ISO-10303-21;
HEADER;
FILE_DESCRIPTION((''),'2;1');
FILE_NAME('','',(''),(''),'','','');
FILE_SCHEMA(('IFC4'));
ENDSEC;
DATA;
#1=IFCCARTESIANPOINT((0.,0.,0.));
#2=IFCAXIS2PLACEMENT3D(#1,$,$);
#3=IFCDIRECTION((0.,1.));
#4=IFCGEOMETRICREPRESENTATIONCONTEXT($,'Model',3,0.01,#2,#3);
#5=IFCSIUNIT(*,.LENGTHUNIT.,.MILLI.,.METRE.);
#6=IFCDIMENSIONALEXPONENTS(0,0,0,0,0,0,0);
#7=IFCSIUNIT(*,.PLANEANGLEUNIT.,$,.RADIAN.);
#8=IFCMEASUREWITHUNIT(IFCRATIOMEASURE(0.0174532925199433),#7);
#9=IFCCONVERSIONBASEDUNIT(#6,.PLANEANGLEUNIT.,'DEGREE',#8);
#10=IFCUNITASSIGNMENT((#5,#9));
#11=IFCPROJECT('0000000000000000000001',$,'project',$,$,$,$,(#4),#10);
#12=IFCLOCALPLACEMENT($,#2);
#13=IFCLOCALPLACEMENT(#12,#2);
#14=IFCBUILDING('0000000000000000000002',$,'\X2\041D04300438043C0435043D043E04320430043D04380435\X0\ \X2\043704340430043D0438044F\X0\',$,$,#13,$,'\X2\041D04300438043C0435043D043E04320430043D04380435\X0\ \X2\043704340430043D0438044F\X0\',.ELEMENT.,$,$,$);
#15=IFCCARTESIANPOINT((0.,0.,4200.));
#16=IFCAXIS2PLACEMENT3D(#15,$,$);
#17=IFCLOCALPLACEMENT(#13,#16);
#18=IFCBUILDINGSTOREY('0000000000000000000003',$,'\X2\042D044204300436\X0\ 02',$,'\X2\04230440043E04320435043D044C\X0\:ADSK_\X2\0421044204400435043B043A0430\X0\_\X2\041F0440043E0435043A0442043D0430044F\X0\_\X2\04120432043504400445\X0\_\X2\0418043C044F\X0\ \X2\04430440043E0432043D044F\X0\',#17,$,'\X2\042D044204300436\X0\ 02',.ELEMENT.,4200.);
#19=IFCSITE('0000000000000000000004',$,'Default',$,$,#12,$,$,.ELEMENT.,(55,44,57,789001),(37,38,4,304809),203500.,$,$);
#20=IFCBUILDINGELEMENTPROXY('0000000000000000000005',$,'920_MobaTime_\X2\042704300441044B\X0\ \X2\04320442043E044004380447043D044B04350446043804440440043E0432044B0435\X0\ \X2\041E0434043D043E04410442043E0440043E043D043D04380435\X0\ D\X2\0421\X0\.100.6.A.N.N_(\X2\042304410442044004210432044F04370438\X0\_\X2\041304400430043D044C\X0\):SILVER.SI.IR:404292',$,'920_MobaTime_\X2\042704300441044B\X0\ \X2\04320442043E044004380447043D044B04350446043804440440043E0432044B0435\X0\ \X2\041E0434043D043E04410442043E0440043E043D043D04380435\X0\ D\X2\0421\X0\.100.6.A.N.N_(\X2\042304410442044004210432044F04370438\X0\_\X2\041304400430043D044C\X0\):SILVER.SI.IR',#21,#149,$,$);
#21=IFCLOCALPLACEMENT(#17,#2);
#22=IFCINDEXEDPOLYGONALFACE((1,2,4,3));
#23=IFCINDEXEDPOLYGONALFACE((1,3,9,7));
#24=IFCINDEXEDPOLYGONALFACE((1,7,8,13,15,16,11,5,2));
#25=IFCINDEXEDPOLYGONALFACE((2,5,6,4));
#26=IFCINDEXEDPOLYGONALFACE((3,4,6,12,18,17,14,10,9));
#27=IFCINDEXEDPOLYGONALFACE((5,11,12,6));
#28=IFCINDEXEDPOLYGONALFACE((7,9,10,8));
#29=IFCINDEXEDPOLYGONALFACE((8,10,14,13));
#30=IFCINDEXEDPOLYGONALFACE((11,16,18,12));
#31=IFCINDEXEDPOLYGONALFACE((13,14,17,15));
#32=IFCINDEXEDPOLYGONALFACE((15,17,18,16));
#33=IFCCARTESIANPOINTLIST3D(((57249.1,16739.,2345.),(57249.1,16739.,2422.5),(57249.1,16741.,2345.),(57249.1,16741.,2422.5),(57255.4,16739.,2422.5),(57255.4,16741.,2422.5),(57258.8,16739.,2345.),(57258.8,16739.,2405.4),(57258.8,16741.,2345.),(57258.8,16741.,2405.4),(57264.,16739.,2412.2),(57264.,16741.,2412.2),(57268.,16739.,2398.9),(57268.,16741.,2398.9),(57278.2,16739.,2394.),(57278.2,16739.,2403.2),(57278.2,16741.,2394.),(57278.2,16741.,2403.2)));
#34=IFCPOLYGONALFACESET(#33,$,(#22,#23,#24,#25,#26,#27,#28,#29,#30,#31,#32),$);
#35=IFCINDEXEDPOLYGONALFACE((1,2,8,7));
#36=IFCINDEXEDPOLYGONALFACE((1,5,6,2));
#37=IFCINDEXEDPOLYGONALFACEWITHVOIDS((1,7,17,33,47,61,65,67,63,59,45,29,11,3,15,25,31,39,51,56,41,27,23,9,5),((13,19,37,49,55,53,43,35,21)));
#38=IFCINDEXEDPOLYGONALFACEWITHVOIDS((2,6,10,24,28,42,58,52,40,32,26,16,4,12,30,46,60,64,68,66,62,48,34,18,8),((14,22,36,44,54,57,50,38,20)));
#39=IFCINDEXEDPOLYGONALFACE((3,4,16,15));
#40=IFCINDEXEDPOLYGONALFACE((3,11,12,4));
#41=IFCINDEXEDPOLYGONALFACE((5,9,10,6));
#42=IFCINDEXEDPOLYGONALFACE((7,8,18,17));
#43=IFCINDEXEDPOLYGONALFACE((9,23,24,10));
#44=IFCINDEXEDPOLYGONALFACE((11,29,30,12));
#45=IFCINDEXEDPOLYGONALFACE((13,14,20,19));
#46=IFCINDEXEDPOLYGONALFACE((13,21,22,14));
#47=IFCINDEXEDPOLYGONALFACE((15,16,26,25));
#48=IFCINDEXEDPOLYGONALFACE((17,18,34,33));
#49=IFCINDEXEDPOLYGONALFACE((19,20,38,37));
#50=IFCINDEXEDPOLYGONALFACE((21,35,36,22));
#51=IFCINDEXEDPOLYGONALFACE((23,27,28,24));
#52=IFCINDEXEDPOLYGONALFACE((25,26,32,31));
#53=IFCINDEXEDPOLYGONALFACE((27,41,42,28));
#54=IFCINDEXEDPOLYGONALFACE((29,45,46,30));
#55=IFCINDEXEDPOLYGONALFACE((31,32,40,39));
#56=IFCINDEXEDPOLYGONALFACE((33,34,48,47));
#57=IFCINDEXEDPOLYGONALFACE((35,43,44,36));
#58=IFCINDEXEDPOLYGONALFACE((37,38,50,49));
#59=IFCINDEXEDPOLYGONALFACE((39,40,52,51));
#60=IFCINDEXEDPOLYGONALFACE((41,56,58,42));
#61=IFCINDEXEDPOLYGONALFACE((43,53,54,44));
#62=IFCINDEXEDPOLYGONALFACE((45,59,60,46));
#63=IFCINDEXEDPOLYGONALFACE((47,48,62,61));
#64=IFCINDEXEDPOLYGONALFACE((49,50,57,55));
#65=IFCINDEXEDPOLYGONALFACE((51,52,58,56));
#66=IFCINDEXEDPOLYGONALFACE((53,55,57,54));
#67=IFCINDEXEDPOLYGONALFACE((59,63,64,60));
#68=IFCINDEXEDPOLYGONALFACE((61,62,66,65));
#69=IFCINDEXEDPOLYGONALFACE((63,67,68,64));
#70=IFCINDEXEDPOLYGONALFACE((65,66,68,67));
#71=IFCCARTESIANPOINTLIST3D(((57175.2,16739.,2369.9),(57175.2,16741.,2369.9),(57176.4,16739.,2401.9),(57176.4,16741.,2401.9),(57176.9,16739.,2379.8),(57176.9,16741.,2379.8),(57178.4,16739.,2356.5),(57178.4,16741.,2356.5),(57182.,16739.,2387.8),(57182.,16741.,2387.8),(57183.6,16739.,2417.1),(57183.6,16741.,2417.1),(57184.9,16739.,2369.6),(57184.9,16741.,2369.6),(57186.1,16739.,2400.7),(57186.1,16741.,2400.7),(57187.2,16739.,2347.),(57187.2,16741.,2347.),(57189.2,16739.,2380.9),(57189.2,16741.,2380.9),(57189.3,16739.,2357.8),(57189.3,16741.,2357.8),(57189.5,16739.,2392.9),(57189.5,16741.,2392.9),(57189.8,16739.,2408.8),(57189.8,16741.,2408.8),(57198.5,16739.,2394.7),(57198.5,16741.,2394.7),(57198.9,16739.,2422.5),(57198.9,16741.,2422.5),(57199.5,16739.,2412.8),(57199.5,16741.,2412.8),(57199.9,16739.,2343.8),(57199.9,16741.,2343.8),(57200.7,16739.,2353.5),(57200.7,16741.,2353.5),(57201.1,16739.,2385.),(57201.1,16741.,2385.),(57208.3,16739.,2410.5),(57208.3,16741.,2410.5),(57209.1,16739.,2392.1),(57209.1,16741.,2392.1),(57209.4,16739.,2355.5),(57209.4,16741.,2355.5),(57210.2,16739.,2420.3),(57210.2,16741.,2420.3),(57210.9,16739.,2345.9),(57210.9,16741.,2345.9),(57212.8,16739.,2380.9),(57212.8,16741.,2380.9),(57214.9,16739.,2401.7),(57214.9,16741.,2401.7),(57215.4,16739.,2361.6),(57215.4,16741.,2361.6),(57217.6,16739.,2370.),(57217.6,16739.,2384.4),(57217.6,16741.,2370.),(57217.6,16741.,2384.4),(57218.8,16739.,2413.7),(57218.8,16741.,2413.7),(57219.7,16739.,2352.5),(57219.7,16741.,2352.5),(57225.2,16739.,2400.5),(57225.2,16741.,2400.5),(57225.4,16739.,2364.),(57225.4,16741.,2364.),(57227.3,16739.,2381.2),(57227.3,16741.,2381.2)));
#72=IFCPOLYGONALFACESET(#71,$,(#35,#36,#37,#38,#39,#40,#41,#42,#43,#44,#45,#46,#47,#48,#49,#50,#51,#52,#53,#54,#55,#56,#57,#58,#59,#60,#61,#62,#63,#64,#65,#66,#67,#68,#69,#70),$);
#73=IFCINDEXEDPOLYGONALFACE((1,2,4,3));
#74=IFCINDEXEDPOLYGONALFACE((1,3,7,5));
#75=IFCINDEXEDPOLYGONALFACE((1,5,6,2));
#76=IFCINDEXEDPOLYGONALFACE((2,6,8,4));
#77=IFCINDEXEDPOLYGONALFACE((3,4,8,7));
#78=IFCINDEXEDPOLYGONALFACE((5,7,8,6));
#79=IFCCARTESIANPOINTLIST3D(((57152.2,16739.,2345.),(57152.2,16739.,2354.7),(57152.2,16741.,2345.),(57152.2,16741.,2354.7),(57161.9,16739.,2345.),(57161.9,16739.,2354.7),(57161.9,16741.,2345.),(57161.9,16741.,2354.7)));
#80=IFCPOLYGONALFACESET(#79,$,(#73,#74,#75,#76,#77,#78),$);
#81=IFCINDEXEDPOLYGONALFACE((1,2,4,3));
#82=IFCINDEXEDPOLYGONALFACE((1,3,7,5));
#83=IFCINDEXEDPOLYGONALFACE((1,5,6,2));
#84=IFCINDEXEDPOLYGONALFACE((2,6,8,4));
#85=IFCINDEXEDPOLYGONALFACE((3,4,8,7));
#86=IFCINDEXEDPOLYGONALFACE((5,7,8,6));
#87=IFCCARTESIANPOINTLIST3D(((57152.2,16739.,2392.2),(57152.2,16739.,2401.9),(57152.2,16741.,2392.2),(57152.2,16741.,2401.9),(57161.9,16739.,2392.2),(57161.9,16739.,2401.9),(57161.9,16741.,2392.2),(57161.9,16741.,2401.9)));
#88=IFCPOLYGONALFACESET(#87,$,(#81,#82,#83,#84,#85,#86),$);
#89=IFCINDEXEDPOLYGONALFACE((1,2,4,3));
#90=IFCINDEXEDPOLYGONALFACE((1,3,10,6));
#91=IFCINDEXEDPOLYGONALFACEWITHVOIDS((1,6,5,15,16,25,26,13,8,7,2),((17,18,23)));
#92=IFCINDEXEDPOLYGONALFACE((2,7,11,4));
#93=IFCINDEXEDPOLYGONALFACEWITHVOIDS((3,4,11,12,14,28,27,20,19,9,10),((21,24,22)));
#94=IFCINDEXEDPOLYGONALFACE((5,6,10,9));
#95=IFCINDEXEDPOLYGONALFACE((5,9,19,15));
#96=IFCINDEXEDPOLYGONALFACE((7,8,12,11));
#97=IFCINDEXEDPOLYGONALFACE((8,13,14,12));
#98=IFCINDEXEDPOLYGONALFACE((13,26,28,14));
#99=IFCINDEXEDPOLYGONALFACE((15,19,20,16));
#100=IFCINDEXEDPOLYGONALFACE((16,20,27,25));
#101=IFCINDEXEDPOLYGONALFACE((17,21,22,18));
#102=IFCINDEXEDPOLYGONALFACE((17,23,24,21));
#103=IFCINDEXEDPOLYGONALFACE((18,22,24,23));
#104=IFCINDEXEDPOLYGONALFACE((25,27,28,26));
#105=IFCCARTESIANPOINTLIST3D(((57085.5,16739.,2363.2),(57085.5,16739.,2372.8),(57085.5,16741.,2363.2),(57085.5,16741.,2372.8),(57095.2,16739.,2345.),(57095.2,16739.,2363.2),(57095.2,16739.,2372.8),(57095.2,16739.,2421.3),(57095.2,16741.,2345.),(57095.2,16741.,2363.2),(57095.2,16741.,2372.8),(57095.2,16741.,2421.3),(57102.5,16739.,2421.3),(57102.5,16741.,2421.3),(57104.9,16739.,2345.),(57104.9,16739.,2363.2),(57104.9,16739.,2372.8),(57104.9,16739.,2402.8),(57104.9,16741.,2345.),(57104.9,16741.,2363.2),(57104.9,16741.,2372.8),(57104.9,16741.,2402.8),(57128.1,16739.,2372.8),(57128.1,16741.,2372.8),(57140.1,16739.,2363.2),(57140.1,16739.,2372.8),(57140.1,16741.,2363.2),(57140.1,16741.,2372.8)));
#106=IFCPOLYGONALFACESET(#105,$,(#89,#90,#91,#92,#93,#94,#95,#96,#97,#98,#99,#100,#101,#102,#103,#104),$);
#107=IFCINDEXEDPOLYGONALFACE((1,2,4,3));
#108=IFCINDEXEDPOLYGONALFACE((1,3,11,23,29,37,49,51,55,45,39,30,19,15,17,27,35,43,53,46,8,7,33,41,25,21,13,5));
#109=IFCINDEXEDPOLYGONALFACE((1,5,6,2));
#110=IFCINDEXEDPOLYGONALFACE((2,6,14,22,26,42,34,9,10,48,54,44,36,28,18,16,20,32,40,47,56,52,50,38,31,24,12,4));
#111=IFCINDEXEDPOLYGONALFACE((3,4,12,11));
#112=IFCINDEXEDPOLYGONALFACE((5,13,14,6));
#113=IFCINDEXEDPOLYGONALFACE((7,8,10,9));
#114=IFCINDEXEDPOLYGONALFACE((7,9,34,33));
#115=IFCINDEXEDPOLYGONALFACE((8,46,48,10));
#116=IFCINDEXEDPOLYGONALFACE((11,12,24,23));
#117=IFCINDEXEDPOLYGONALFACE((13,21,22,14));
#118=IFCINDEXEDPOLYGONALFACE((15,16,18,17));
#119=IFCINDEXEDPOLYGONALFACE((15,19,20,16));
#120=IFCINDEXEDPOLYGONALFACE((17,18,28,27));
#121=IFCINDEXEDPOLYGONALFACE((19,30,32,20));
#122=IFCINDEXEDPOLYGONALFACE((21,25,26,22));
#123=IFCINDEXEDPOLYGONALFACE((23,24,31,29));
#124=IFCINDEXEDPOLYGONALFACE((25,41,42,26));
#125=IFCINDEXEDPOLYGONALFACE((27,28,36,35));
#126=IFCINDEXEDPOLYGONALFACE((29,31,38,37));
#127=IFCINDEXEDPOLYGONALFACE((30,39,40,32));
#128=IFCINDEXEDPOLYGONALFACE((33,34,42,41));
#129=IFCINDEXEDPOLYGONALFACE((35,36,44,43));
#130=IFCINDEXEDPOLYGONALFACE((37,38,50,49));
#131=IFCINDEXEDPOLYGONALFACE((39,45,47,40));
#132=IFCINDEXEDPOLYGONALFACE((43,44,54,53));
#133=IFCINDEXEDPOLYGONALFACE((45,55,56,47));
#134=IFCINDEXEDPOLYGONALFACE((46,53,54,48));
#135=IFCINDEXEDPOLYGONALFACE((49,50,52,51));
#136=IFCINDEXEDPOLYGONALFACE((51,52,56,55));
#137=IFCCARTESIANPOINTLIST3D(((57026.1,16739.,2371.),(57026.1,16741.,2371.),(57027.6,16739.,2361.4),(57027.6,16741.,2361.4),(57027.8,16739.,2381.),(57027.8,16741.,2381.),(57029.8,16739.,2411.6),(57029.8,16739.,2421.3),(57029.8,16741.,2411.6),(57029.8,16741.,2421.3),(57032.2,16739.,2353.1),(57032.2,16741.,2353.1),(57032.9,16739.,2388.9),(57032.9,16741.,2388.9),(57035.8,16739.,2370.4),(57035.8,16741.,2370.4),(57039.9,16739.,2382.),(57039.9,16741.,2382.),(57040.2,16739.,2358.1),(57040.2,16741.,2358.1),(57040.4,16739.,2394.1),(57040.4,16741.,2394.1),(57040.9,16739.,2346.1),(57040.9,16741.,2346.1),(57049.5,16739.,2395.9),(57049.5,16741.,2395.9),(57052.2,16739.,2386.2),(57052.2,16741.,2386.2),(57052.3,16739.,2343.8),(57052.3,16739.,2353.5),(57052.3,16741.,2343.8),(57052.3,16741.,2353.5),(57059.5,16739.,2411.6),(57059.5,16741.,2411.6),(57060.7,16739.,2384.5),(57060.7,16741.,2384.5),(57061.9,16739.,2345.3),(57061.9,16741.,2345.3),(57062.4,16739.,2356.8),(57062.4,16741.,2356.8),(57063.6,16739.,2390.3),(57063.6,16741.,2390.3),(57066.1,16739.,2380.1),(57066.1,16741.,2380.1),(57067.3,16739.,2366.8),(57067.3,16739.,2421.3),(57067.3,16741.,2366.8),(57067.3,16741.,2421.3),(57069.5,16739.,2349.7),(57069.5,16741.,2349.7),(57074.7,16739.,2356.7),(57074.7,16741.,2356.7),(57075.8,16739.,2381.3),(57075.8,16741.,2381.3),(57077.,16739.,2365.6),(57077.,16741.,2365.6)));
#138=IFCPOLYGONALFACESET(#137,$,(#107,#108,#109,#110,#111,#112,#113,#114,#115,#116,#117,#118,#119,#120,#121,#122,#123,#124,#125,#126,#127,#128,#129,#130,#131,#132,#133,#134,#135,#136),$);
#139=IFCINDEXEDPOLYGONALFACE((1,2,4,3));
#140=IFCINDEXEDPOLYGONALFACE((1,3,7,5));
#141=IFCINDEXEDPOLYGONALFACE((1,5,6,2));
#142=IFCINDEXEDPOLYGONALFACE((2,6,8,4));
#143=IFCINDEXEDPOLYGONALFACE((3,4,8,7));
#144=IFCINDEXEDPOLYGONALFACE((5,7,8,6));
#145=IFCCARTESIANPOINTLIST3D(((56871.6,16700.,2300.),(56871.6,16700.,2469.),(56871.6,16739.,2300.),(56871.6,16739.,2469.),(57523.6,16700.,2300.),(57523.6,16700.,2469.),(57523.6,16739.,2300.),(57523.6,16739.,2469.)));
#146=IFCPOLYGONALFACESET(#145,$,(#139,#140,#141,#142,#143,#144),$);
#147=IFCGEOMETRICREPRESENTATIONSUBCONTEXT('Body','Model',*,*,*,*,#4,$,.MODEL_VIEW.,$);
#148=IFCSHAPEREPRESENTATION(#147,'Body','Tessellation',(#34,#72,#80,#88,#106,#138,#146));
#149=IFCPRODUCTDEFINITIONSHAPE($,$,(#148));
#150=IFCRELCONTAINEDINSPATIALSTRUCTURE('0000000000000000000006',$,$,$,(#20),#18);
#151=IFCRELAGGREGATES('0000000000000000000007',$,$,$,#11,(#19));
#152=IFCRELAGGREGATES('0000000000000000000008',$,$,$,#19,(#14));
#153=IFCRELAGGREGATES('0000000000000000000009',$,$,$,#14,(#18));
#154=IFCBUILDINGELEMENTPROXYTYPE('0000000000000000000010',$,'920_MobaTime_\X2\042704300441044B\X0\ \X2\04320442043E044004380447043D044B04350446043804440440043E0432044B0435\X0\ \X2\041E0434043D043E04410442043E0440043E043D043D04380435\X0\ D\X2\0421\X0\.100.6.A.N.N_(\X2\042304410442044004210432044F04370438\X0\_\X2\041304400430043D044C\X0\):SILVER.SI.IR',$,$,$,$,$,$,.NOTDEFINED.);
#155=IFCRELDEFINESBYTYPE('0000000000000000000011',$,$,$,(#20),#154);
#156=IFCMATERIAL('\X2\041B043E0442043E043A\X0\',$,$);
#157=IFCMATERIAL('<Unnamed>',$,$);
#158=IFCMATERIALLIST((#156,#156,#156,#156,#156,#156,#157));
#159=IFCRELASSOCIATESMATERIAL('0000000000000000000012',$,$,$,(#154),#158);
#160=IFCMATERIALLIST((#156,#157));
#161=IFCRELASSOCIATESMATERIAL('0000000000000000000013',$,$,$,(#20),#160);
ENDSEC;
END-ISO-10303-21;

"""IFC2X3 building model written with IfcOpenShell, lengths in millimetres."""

from ifc_helpers import new_model, entity, si_unit, converted_unit, direction, frame, origin, origin_2d_with_axis, place, context, subcontext, project, spatial, polyline, rectangle, outline, extrude, source, transform, mapped, material, material_list, type_object, type_shapes, element, save


model = new_model("IFC2X3")

# Units and contexts
model_context = context("Model", 3, precision=0.01, world=origin(), true_north=direction((0.0, 1.0)))
body_context = subcontext(model_context, "Body", "Model", "MODEL_VIEW")
ifc_project = project(units=[si_unit("LENGTHUNIT", "METRE", prefix="MILLI"), converted_unit("PLANEANGLEUNIT", "DEGREE", entity("IfcRatioMeasure", 0.0174532925199433), si_unit("PLANEANGLEUNIT", "RADIAN"), dimensions=[0, 0, 0, 0, 0, 0, 0])], contexts=[model_context])

# Site, building, storey
site_placement = place(None, frame((0.0, 0.0, 0.0)))
site = spatial("IfcSite", under=ifc_project, at=site_placement, Name="Default", CompositionType="ELEMENT", RefLatitude=(55, 44, 57, 789001), RefLongitude=(37, 38, 4, 304809), RefElevation=203500.0)
building_placement = place(site_placement, origin())
building = spatial("IfcBuilding", under=site, at=building_placement, Name="Наименование здания", LongName="Наименование здания", CompositionType="ELEMENT")
storey_placement = place(building_placement, frame((0.0, 0.0, 4200.0)))
storey = spatial("IfcBuildingStorey", under=building, at=storey_placement, Name="Этаж 02", ObjectType="Уровень:ADSK_Стрелка_Проектная_Вверх_Имя уровня", LongName="Этаж 02", CompositionType="ELEMENT", Elevation=4200.0)

# Building element proxy
ifc_material_1 = material(Name="Лоток")
ifc_material_2 = material(Name="<Unnamed>")
ifc_material_list_1 = material_list([ifc_material_1, ifc_material_1, ifc_material_1, ifc_material_1, ifc_material_1, ifc_material_1, ifc_material_2])
building_element_proxy_type_1 = type_object("IfcBuildingElementProxyType", Name="920_MobaTime_Часы вторичныецифровые Односторонние DС.100.6.A.N.N_(УстрСвязи_Грань):SILVER.SI.IR", PredefinedType="NOTDEFINED", material=ifc_material_list_1)
shared_shape_1 = source(origin(), body_context, "Body", "SweptSolid", [
    extrude(outline(polyline([(-49.3, -13.1), (28.2, -13.1), (28.2, -6.8), (17.9, 1.8), (8.9, 16.0), (-0.3, 16.0), (4.6, 5.8), (11.1, -3.4), (-49.3, -3.4), (-49.3, -13.1)])), frame((-64.6, 9.8, 39.0), z_axis=(0.0, 0.0, 1.0), x_axis=(0.0, 1.0, 0.0)), (0.0, 0.0, 1.0), 2.0),
    extrude(outline(polyline([(2.2, -27.6), (19.0, -27.6), (30.5, -16.1), (33.3, -4.9), (31.0, 5.8), (21.8, 17.2), (5.2, 27.3), (-11.1, 33.0), (-24.0, 32.7), (-33.6, 27.6), (-40.3, 18.6), (-42.8, 5.7), (-38.0, -6.3), (-27.2, -15.0), (-17.5, -17.7), (-8.2, -16.4), (-0.3, -11.9), (5.1, -4.5), (7.3, 6.2), (4.0, 17.2), (18.5, 7.3), (23.6, -2.4), (22.0, -11.4), (14.2, -18.4), (5.3, -18.3), (2.2, -27.6)]), holes=[polyline([(-9.0, 23.3), (-1.3, 14.4), (-2.6, 2.0), (-11.4, -7.0), (-23.4, -6.1), (-32.2, 2.9), (-31.2, 15.1), (-25.6, 22.1), (-17.5, 24.9), (-9.0, 23.3)])]), frame((-2.7, 3.6, 39.0), z_axis=(0.0, 0.0, 1.0), x_axis=(-0.427649, 0.903945, 0.0)), (0.0, 0.0, 1.0), 2.0),
    extrude(rectangle(XDim=9.7, YDim=9.7, at=origin_2d_with_axis()), frame((40.6, -34.7, 39.0)), (0.0, 0.0, 1.0), 2.0),
    extrude(rectangle(XDim=9.7, YDim=9.7, at=origin_2d_with_axis()), frame((40.6, 12.6, 39.0)), (0.0, 0.0, 1.0), 2.0),
    extrude(outline(polyline([(-0.9, -28.1), (8.8, -28.1), (8.8, -9.9), (18.5, -9.9), (18.5, -0.2), (8.8, -0.2), (8.8, 48.3), (1.5, 48.3), (-36.0, -0.2), (-36.0, -9.9), (-0.9, -9.9), (-0.9, -28.1)]), holes=[polyline([(-0.9, -0.2), (-24.1, -0.2), (-0.9, 29.7), (-0.9, -0.2)])]), frame((93.6, -11.4, 39.0)), (0.0, 0.0, 1.0), 2.0),
    extrude(outline(polyline([(3.3, -28.3), (12.5, -28.3), (20.5, -25.0), (26.8, -18.8), (30.7, -10.0), (31.4, 1.6), (26.9, 11.8), (20.1, 18.4), (11.1, 22.3), (1.0, 23.3), (-7.9, 20.4), (-14.9, 14.5), (-18.9, 6.2), (-17.1, -9.0), (-36.7, 0.5), (-29.1, 29.3), (-38.5, 31.7), (-48.1, -4.6), (-11.6, -23.0), (-8.0, -14.0), (-10.8, -7.6), (-10.2, 1.1), (-3.0, 11.8), (9.2, 12.8), (20.0, 5.4), (21.3, -7.5), (15.5, -16.4), (4.6, -18.6), (3.3, -28.3)])), frame((147.1, -8.5, 39.0), z_axis=(0.0, 0.0, 1.0), x_axis=(0.256974, -0.966418, 0.0)), (0.0, 0.0, 1.0), 2.0),
    extrude(rectangle(XDim=652.0, YDim=169.0, at=origin_2d_with_axis()), frame((0.0, 0.0, 0.0), z_axis=(0.0, 0.0, 1.0), x_axis=(-1.0, 0.0, 0.0)), (0.0, 0.0, 1.0), 39.0),
])
type_shapes(building_element_proxy_type_1, [shared_shape_1])
ifc_material_list_2 = material_list([ifc_material_1, ifc_material_2])
proxy_1_placement = place(storey_placement, frame((57197.6, 16700.0, 2384.5), z_axis=(0.0, 1.0, 0.0), x_axis=(-1.0, 0.0, 0.0)))
element("IfcBuildingElementProxy", 1, at=proxy_1_placement, inside=storey, type_object=building_element_proxy_type_1, material=ifc_material_list_2, Name="920_MobaTime_Часы вторичныецифровые Односторонние DС.100.6.A.N.N_(УстрСвязи_Грань):SILVER.SI.IR:404292", ObjectType="920_MobaTime_Часы вторичныецифровые Односторонние DС.100.6.A.N.N_(УстрСвязи_Грань):SILVER.SI.IR", context=body_context, shape_type="MappedRepresentation", body=[
    mapped(shared_shape_1, transform((0.0, 0.0, 0.0), scale=1.0)),
])

save(model, "model.ifc")
